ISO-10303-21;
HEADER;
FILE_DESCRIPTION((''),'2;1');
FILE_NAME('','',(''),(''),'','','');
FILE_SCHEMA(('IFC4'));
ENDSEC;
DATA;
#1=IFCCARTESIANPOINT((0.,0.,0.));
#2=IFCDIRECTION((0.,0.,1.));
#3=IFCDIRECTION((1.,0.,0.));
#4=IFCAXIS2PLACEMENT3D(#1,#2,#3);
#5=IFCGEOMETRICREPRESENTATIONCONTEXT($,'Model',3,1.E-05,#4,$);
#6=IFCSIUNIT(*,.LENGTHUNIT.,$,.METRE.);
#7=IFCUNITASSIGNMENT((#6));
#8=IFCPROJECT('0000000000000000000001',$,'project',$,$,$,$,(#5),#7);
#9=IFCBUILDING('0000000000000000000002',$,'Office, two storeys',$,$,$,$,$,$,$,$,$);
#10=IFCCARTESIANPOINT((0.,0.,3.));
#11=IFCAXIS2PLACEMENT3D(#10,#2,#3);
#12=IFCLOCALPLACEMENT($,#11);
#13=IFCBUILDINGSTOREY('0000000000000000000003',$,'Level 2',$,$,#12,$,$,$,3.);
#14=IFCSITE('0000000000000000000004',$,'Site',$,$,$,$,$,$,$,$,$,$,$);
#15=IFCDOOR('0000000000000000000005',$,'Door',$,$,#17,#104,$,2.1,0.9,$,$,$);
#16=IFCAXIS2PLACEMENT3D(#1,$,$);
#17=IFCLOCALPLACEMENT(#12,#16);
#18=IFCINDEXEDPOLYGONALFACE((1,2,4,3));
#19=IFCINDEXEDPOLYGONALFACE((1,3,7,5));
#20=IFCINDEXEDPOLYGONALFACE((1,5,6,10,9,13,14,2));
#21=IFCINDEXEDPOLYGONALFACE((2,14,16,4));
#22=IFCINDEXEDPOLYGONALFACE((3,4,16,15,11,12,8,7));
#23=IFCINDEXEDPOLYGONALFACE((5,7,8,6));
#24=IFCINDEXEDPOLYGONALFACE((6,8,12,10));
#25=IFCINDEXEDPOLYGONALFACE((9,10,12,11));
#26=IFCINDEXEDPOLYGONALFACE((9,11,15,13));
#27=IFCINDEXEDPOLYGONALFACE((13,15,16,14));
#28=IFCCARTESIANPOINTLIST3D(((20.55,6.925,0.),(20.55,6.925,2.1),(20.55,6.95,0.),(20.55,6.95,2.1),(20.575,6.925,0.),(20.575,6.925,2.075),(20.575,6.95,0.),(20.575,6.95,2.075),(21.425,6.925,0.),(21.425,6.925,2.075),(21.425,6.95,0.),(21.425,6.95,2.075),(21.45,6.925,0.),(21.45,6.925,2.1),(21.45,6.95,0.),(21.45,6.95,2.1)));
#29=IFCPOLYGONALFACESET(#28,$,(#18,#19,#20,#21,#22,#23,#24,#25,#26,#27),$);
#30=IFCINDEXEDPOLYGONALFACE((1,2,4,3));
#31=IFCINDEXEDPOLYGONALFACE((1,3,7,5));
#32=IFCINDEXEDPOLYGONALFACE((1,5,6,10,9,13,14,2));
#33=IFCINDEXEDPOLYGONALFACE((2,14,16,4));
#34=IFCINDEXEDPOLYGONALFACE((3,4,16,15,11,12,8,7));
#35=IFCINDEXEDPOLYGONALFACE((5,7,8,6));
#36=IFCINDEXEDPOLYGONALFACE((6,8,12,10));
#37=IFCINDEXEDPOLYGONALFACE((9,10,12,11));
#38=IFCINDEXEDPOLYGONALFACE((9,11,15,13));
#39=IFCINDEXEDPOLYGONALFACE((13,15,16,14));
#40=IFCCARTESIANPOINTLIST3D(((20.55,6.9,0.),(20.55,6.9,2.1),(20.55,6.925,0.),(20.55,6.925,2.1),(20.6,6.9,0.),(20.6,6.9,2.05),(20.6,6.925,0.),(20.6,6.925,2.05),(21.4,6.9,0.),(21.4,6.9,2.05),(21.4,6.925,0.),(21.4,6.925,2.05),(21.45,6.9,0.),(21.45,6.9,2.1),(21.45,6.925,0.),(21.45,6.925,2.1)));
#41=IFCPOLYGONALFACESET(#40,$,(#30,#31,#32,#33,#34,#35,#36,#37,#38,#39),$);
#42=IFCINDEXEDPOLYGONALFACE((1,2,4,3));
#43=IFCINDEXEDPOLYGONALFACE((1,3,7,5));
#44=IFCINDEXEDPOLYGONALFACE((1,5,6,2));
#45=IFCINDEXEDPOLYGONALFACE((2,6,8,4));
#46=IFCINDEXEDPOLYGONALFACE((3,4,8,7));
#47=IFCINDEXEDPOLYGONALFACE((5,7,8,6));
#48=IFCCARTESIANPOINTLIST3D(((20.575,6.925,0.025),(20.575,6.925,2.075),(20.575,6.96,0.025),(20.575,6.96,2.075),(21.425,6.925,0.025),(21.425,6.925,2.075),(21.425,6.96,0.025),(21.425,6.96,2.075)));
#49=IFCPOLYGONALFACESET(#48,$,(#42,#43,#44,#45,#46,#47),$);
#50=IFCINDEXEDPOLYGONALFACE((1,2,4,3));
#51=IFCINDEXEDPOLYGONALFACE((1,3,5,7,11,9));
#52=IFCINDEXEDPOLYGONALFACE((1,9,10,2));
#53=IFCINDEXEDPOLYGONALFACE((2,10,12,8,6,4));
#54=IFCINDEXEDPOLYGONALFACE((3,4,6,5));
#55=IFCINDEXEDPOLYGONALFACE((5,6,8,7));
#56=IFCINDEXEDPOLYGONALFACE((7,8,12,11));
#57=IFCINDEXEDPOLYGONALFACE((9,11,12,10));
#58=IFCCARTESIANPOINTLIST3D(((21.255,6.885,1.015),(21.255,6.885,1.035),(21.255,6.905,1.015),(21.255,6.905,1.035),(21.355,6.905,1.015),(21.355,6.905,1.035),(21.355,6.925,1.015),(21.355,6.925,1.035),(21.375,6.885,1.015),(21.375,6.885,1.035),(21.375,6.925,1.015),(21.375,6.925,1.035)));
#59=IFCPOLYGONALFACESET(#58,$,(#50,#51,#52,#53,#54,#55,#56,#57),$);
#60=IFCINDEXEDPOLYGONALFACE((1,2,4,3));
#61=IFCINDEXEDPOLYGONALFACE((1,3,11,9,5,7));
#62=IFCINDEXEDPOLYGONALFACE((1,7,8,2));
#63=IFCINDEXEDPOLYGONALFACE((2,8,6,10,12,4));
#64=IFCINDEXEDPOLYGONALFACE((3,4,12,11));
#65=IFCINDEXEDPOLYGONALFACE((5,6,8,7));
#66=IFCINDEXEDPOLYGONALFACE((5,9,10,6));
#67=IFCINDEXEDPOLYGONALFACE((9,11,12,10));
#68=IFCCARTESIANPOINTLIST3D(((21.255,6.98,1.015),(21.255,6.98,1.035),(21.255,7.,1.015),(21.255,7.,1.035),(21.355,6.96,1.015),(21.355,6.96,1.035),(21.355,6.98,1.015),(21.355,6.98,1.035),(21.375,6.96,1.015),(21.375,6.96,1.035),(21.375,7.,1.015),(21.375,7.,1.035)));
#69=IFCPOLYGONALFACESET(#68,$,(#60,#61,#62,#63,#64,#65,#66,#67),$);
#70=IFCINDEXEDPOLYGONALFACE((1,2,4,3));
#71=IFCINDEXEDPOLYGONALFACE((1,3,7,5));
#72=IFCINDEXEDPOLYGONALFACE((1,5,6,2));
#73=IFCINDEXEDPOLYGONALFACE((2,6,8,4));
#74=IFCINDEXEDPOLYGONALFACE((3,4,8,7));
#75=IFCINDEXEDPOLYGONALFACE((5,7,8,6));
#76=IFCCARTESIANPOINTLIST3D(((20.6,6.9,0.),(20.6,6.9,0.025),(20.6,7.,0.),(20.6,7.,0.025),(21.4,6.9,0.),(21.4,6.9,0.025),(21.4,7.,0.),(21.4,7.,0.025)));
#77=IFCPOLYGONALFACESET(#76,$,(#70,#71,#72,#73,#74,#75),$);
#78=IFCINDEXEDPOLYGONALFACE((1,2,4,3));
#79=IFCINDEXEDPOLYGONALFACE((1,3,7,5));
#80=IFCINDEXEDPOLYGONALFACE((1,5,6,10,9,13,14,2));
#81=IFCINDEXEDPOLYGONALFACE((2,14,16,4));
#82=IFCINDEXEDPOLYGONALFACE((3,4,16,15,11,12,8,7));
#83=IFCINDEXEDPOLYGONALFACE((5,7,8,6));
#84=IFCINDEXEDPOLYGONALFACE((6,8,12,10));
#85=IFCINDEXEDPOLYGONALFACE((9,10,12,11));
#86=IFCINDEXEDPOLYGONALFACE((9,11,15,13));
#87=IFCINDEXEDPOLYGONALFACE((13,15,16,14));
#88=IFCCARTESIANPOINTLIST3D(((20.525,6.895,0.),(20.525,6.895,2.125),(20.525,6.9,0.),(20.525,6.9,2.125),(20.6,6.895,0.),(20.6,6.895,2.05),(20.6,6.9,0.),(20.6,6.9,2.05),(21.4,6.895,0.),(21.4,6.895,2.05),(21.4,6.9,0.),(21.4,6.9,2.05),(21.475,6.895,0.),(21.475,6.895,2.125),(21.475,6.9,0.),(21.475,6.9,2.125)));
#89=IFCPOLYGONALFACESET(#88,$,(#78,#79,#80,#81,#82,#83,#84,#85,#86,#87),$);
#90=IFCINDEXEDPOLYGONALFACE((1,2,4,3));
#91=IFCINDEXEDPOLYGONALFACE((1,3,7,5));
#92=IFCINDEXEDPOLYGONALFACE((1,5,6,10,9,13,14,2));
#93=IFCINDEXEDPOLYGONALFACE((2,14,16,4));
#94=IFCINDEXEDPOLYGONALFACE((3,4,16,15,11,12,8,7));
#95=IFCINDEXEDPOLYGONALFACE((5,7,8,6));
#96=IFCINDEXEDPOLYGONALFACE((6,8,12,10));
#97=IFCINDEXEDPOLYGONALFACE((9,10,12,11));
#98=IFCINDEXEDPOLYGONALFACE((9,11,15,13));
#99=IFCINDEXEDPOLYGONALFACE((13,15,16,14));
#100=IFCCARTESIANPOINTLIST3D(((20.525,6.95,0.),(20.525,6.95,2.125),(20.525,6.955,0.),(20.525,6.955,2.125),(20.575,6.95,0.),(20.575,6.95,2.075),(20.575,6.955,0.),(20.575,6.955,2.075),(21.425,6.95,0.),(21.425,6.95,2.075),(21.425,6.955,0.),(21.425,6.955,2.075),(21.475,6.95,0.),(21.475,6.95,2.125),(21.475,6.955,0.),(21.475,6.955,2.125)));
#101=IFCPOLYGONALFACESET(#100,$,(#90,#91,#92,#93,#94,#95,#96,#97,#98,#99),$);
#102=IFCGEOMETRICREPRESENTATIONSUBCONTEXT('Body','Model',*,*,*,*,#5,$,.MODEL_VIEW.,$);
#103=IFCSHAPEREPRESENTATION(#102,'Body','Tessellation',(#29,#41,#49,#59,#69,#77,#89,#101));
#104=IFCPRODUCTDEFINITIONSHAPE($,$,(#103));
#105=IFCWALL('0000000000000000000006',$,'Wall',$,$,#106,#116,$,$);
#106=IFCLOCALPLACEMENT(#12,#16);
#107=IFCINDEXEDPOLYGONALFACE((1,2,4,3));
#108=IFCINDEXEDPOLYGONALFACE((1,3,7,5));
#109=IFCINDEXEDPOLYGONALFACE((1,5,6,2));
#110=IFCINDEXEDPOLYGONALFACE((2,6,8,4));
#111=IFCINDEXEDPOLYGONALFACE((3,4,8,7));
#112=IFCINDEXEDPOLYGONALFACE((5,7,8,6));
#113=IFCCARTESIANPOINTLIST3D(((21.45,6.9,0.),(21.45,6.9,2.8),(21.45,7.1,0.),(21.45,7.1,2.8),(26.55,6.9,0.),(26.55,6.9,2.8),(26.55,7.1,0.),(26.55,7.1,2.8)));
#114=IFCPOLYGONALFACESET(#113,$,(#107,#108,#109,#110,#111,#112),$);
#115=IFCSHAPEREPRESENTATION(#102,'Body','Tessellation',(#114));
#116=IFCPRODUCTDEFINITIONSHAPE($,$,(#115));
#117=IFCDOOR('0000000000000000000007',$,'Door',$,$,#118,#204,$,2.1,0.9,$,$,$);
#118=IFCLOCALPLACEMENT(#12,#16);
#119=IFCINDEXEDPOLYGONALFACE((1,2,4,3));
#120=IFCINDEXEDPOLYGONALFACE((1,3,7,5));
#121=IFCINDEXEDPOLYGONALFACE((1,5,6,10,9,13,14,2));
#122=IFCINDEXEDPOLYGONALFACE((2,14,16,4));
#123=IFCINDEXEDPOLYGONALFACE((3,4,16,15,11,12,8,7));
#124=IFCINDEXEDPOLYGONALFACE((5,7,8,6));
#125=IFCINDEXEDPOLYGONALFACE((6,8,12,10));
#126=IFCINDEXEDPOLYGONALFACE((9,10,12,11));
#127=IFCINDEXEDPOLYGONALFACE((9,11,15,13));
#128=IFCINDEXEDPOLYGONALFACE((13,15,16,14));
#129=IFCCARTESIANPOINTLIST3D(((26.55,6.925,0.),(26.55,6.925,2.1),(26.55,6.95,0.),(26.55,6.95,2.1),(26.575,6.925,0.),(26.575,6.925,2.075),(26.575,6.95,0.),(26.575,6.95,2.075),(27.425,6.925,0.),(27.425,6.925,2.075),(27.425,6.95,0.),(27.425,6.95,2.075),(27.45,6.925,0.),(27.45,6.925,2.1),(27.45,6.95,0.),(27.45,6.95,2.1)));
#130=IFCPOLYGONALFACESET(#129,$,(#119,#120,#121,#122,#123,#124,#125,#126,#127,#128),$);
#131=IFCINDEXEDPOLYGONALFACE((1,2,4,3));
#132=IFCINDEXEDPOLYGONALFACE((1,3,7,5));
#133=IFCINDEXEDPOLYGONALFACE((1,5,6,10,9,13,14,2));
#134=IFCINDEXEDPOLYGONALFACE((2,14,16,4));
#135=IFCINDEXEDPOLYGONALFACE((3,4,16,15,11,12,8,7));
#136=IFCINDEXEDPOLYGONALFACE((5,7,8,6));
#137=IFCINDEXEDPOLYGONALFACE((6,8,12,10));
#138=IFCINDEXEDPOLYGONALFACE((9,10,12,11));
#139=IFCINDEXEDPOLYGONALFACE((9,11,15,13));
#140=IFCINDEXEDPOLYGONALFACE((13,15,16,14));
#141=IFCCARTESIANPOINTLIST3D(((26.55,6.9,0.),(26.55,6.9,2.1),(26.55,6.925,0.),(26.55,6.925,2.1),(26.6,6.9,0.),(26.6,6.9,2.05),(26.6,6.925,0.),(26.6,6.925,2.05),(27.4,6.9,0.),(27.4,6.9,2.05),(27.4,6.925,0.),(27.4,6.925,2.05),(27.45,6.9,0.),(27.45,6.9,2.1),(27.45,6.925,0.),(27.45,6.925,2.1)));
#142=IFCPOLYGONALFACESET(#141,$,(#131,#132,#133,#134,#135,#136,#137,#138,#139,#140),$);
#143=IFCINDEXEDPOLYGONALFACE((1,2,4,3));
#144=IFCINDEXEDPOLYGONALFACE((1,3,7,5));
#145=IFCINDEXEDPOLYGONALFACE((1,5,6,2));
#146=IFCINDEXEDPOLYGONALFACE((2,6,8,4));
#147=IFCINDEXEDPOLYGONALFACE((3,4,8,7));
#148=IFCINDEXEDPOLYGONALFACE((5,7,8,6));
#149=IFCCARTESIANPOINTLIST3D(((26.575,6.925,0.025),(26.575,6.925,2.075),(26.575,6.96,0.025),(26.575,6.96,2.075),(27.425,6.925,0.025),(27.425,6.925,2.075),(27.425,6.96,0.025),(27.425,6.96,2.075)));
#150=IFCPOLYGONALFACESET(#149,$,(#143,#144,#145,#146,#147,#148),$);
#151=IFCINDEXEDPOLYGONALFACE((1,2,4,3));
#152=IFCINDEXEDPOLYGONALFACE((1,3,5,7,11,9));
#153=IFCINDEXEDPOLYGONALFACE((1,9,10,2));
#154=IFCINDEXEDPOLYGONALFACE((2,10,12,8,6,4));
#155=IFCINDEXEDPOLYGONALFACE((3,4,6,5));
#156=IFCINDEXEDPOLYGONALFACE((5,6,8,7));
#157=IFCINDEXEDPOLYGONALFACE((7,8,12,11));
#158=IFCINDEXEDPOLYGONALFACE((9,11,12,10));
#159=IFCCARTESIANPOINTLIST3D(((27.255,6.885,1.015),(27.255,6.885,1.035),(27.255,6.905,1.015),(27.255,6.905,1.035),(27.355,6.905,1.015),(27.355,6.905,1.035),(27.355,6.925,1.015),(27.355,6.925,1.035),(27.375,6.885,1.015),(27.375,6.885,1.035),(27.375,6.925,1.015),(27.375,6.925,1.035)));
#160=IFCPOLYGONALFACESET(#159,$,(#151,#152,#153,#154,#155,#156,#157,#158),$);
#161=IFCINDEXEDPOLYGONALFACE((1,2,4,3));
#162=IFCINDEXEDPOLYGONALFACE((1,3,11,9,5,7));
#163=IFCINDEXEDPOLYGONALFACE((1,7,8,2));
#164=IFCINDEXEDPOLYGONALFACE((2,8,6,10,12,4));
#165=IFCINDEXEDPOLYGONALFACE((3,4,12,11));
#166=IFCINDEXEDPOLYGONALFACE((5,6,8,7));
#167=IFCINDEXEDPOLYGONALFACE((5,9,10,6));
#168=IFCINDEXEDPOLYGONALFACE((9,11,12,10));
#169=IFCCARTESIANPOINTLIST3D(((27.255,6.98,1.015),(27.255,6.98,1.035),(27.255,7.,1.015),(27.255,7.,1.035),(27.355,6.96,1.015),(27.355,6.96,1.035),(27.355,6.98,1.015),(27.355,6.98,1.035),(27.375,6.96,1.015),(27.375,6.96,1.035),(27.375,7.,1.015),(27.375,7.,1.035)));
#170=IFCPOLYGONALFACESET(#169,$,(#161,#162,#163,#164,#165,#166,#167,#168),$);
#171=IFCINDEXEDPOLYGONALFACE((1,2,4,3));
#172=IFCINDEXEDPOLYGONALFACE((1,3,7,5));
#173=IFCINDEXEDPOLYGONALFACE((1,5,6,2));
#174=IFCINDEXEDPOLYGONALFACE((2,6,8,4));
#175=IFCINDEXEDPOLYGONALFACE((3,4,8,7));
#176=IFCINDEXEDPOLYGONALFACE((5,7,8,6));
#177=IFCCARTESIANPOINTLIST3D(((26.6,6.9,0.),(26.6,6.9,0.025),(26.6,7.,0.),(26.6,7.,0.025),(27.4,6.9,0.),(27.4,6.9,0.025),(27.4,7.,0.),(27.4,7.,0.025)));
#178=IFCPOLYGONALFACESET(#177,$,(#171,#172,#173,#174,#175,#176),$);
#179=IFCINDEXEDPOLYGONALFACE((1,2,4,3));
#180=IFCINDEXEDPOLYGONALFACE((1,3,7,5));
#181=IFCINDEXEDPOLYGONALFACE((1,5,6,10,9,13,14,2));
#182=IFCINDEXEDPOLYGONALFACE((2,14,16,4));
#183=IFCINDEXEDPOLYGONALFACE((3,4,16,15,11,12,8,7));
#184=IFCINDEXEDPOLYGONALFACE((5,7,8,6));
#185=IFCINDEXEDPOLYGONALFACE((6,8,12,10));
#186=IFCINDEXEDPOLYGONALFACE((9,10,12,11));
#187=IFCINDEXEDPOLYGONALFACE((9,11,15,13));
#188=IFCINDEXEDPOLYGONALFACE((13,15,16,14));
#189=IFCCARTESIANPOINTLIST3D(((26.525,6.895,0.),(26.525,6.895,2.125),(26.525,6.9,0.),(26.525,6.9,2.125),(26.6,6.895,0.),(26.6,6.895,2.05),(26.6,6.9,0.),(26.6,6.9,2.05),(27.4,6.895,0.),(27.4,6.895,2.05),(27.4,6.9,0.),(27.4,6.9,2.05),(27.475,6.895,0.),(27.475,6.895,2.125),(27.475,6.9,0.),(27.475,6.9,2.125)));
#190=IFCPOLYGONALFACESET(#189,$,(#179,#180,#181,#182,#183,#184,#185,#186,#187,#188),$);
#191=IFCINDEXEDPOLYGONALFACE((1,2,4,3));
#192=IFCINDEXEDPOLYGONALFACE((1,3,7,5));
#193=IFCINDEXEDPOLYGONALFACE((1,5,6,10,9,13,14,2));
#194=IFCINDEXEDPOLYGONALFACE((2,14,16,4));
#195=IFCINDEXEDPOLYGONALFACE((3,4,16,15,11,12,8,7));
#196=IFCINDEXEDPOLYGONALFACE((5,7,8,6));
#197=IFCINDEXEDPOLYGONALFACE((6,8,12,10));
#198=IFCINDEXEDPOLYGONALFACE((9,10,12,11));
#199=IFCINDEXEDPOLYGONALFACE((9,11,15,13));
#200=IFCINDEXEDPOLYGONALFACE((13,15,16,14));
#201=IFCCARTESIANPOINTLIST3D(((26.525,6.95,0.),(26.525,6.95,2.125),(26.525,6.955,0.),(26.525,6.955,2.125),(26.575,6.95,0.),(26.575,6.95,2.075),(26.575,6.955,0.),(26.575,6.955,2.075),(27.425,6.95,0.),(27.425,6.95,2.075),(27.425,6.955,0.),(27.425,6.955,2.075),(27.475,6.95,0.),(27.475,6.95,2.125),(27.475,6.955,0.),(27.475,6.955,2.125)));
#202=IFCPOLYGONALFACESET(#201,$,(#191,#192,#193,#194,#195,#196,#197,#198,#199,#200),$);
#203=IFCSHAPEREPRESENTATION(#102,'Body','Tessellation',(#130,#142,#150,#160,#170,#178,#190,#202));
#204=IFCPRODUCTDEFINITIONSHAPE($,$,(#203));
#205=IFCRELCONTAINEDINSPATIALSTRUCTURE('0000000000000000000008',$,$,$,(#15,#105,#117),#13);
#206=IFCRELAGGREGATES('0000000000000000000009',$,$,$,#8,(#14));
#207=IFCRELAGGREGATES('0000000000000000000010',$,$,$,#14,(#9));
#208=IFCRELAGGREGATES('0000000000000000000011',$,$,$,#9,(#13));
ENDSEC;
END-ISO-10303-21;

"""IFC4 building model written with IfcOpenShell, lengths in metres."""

from ifc_helpers import new_model, si_unit, frame, origin_with_axes, place, context, subcontext, project, spatial, line, indexed_curve, outline, extrude, element, save


model = new_model("IFC4")

# Units and contexts
model_context = context("Model", 3, precision=1e-05, world=origin_with_axes())
body_context = subcontext(model_context, "Body", "Model", "MODEL_VIEW")
ifc_project = project(units=[si_unit("LENGTHUNIT", "METRE")], contexts=[model_context])

# Site, building, storey
site = spatial("IfcSite", under=ifc_project, Name="Site")
building = spatial("IfcBuilding", under=site, Name="Office, two storeys")
storey_placement = place(None, frame((0.0, 0.0, 3.0), z_axis=(0.0, 0.0, 1.0), x_axis=(1.0, 0.0, 0.0)))
storey = spatial("IfcBuildingStorey", under=building, at=storey_placement, Name="Level 2", Elevation=3.0)

# Door
door_1_placement = place(storey_placement, frame((20.55, 6.9, 0.0), z_axis=(0.0, 0.0, 1.0), x_axis=(1.0, 0.0, 0.0)))
element("IfcDoor", 1, at=door_1_placement, inside=storey, Name="Door", OverallHeight=2.1, OverallWidth=0.9, context=body_context, shape_type="SweptSolid", body=[
    extrude(outline(indexed_curve([(0.0, 0.0), (0.0, 2.1), (0.9, 2.1), (0.9, 0.0), (0.875, 0.0), (0.875, 2.075), (0.025, 2.075), (0.025, 0.0)], segments=[line(1, 2, 3, 4, 5, 6, 7, 8, 1)])), frame((0.0, 0.025, 0.0), z_axis=(0.0, -1.0, 0.0), x_axis=(1.0, 0.0, 0.0)), (0.0, 0.0, -1.0), 0.025),
    extrude(outline(indexed_curve([(0.0, 0.0), (0.0, 2.1), (0.9, 2.1), (0.9, 0.0), (0.85, 0.0), (0.85, 2.05), (0.05, 2.05), (0.05, 0.0)], segments=[line(1, 2, 3, 4, 5, 6, 7, 8, 1)])), frame((0.0, 0.0, 0.0), z_axis=(0.0, -1.0, 0.0), x_axis=(1.0, 0.0, 0.0)), (0.0, 0.0, -1.0), 0.025),
    extrude(outline(indexed_curve([(0.0, 0.0), (0.85, 0.0), (0.85, 0.035), (0.0, 0.035)], segments=[line(1, 2, 3, 4, 1)])), frame((0.025, 0.025, 0.025), z_axis=(0.0, 0.0, 1.0), x_axis=(1.0, 0.0, 0.0)), (0.0, 0.0, 1.0), 2.05),
    extrude(outline(indexed_curve([(0.0, 0.0), (0.0, -0.04), (-0.12, -0.04), (-0.12, -0.02), (-0.02, -0.02), (-0.02, 0.0)], segments=[line(1, 2, 3, 4, 5, 6, 1)])), frame((0.825, 0.025, 1.015), z_axis=(0.0, 0.0, 1.0), x_axis=(1.0, 0.0, 0.0)), (0.0, 0.0, 1.0), 0.02),
    extrude(outline(indexed_curve([(0.0, 0.0), (0.0, 0.04), (-0.12, 0.04), (-0.12, 0.02), (-0.02, 0.02), (-0.02, 0.0)], segments=[line(1, 2, 3, 4, 5, 6, 1)])), frame((0.825, 0.06, 1.015), z_axis=(0.0, 0.0, 1.0), x_axis=(1.0, 0.0, 0.0)), (0.0, 0.0, 1.0), 0.02),
    extrude(outline(indexed_curve([(0.0, 0.0), (0.8, 0.0), (0.8, 0.1), (0.0, 0.1)], segments=[line(1, 2, 3, 4, 1)])), frame((0.05, 0.0, 0.0), z_axis=(0.0, 0.0, 1.0), x_axis=(1.0, 0.0, 0.0)), (0.0, 0.0, 1.0), 0.025),
    extrude(outline(indexed_curve([(0.0, 0.0), (0.0, 2.125), (0.95, 2.125), (0.95, 0.0), (0.875, 0.0), (0.875, 2.05), (0.075, 2.05), (0.075, 0.0)], segments=[line(1, 2, 3, 4, 5, 6, 7, 8, 1)])), frame((-0.025, -0.005, 0.0), z_axis=(0.0, -1.0, 0.0), x_axis=(1.0, 0.0, 0.0)), (0.0, 0.0, -1.0), 0.005),
    extrude(outline(indexed_curve([(0.0, 0.0), (0.0, 2.125), (0.95, 2.125), (0.95, 0.0), (0.9, 0.0), (0.9, 2.075), (0.05, 2.075), (0.05, 0.0)], segments=[line(1, 2, 3, 4, 5, 6, 7, 8, 1)])), frame((-0.025, 0.05, 0.0), z_axis=(0.0, -1.0, 0.0), x_axis=(1.0, 0.0, 0.0)), (0.0, 0.0, -1.0), 0.005),
])

# Wall
wall_1_placement = place(storey_placement, frame((21.45, 7.0, 0.0), z_axis=(0.0, 0.0, 1.0), x_axis=(1.0, 0.0, 0.0)))
element("IfcWall", 2, at=wall_1_placement, inside=storey, Name="Wall", context=body_context, shape_type="SweptSolid", body=[
    extrude(outline(indexed_curve([(0.0, 0.0), (0.0, 0.2), (5.1, 0.2), (5.1, 0.0), (0.0, 0.0)], self_intersect=False)), frame((0.0, -0.1, 0.0), z_axis=(0.0, 0.0, 1.0), x_axis=(1.0, 0.0, 0.0)), (0.0, 0.0, 1.0), 2.8),
])

# Door
door_2_placement = place(storey_placement, frame((26.55, 6.9, 0.0), z_axis=(0.0, 0.0, 1.0), x_axis=(1.0, 0.0, 0.0)))
element("IfcDoor", 3, at=door_2_placement, inside=storey, Name="Door", OverallHeight=2.1, OverallWidth=0.9, context=body_context, shape_type="SweptSolid", body=[
    extrude(outline(indexed_curve([(0.0, 0.0), (0.0, 2.1), (0.9, 2.1), (0.9, 0.0), (0.875, 0.0), (0.875, 2.075), (0.025, 2.075), (0.025, 0.0)], segments=[line(1, 2, 3, 4, 5, 6, 7, 8, 1)])), frame((0.0, 0.025, 0.0), z_axis=(0.0, -1.0, 0.0), x_axis=(1.0, 0.0, 0.0)), (0.0, 0.0, -1.0), 0.025),
    extrude(outline(indexed_curve([(0.0, 0.0), (0.0, 2.1), (0.9, 2.1), (0.9, 0.0), (0.85, 0.0), (0.85, 2.05), (0.05, 2.05), (0.05, 0.0)], segments=[line(1, 2, 3, 4, 5, 6, 7, 8, 1)])), frame((0.0, 0.0, 0.0), z_axis=(0.0, -1.0, 0.0), x_axis=(1.0, 0.0, 0.0)), (0.0, 0.0, -1.0), 0.025),
    extrude(outline(indexed_curve([(0.0, 0.0), (0.85, 0.0), (0.85, 0.035), (0.0, 0.035)], segments=[line(1, 2, 3, 4, 1)])), frame((0.025, 0.025, 0.025), z_axis=(0.0, 0.0, 1.0), x_axis=(1.0, 0.0, 0.0)), (0.0, 0.0, 1.0), 2.05),
    extrude(outline(indexed_curve([(0.0, 0.0), (0.0, -0.04), (-0.12, -0.04), (-0.12, -0.02), (-0.02, -0.02), (-0.02, 0.0)], segments=[line(1, 2, 3, 4, 5, 6, 1)])), frame((0.825, 0.025, 1.015), z_axis=(0.0, 0.0, 1.0), x_axis=(1.0, 0.0, 0.0)), (0.0, 0.0, 1.0), 0.02),
    extrude(outline(indexed_curve([(0.0, 0.0), (0.0, 0.04), (-0.12, 0.04), (-0.12, 0.02), (-0.02, 0.02), (-0.02, 0.0)], segments=[line(1, 2, 3, 4, 5, 6, 1)])), frame((0.825, 0.06, 1.015), z_axis=(0.0, 0.0, 1.0), x_axis=(1.0, 0.0, 0.0)), (0.0, 0.0, 1.0), 0.02),
    extrude(outline(indexed_curve([(0.0, 0.0), (0.8, 0.0), (0.8, 0.1), (0.0, 0.1)], segments=[line(1, 2, 3, 4, 1)])), frame((0.05, 0.0, 0.0), z_axis=(0.0, 0.0, 1.0), x_axis=(1.0, 0.0, 0.0)), (0.0, 0.0, 1.0), 0.025),
    extrude(outline(indexed_curve([(0.0, 0.0), (0.0, 2.125), (0.95, 2.125), (0.95, 0.0), (0.875, 0.0), (0.875, 2.05), (0.075, 2.05), (0.075, 0.0)], segments=[line(1, 2, 3, 4, 5, 6, 7, 8, 1)])), frame((-0.025, -0.005, 0.0), z_axis=(0.0, -1.0, 0.0), x_axis=(1.0, 0.0, 0.0)), (0.0, 0.0, -1.0), 0.005),
    extrude(outline(indexed_curve([(0.0, 0.0), (0.0, 2.125), (0.95, 2.125), (0.95, 0.0), (0.9, 0.0), (0.9, 2.075), (0.05, 2.075), (0.05, 0.0)], segments=[line(1, 2, 3, 4, 5, 6, 7, 8, 1)])), frame((-0.025, 0.05, 0.0), z_axis=(0.0, -1.0, 0.0), x_axis=(1.0, 0.0, 0.0)), (0.0, 0.0, -1.0), 0.005),
])

save(model, "model.ifc")
